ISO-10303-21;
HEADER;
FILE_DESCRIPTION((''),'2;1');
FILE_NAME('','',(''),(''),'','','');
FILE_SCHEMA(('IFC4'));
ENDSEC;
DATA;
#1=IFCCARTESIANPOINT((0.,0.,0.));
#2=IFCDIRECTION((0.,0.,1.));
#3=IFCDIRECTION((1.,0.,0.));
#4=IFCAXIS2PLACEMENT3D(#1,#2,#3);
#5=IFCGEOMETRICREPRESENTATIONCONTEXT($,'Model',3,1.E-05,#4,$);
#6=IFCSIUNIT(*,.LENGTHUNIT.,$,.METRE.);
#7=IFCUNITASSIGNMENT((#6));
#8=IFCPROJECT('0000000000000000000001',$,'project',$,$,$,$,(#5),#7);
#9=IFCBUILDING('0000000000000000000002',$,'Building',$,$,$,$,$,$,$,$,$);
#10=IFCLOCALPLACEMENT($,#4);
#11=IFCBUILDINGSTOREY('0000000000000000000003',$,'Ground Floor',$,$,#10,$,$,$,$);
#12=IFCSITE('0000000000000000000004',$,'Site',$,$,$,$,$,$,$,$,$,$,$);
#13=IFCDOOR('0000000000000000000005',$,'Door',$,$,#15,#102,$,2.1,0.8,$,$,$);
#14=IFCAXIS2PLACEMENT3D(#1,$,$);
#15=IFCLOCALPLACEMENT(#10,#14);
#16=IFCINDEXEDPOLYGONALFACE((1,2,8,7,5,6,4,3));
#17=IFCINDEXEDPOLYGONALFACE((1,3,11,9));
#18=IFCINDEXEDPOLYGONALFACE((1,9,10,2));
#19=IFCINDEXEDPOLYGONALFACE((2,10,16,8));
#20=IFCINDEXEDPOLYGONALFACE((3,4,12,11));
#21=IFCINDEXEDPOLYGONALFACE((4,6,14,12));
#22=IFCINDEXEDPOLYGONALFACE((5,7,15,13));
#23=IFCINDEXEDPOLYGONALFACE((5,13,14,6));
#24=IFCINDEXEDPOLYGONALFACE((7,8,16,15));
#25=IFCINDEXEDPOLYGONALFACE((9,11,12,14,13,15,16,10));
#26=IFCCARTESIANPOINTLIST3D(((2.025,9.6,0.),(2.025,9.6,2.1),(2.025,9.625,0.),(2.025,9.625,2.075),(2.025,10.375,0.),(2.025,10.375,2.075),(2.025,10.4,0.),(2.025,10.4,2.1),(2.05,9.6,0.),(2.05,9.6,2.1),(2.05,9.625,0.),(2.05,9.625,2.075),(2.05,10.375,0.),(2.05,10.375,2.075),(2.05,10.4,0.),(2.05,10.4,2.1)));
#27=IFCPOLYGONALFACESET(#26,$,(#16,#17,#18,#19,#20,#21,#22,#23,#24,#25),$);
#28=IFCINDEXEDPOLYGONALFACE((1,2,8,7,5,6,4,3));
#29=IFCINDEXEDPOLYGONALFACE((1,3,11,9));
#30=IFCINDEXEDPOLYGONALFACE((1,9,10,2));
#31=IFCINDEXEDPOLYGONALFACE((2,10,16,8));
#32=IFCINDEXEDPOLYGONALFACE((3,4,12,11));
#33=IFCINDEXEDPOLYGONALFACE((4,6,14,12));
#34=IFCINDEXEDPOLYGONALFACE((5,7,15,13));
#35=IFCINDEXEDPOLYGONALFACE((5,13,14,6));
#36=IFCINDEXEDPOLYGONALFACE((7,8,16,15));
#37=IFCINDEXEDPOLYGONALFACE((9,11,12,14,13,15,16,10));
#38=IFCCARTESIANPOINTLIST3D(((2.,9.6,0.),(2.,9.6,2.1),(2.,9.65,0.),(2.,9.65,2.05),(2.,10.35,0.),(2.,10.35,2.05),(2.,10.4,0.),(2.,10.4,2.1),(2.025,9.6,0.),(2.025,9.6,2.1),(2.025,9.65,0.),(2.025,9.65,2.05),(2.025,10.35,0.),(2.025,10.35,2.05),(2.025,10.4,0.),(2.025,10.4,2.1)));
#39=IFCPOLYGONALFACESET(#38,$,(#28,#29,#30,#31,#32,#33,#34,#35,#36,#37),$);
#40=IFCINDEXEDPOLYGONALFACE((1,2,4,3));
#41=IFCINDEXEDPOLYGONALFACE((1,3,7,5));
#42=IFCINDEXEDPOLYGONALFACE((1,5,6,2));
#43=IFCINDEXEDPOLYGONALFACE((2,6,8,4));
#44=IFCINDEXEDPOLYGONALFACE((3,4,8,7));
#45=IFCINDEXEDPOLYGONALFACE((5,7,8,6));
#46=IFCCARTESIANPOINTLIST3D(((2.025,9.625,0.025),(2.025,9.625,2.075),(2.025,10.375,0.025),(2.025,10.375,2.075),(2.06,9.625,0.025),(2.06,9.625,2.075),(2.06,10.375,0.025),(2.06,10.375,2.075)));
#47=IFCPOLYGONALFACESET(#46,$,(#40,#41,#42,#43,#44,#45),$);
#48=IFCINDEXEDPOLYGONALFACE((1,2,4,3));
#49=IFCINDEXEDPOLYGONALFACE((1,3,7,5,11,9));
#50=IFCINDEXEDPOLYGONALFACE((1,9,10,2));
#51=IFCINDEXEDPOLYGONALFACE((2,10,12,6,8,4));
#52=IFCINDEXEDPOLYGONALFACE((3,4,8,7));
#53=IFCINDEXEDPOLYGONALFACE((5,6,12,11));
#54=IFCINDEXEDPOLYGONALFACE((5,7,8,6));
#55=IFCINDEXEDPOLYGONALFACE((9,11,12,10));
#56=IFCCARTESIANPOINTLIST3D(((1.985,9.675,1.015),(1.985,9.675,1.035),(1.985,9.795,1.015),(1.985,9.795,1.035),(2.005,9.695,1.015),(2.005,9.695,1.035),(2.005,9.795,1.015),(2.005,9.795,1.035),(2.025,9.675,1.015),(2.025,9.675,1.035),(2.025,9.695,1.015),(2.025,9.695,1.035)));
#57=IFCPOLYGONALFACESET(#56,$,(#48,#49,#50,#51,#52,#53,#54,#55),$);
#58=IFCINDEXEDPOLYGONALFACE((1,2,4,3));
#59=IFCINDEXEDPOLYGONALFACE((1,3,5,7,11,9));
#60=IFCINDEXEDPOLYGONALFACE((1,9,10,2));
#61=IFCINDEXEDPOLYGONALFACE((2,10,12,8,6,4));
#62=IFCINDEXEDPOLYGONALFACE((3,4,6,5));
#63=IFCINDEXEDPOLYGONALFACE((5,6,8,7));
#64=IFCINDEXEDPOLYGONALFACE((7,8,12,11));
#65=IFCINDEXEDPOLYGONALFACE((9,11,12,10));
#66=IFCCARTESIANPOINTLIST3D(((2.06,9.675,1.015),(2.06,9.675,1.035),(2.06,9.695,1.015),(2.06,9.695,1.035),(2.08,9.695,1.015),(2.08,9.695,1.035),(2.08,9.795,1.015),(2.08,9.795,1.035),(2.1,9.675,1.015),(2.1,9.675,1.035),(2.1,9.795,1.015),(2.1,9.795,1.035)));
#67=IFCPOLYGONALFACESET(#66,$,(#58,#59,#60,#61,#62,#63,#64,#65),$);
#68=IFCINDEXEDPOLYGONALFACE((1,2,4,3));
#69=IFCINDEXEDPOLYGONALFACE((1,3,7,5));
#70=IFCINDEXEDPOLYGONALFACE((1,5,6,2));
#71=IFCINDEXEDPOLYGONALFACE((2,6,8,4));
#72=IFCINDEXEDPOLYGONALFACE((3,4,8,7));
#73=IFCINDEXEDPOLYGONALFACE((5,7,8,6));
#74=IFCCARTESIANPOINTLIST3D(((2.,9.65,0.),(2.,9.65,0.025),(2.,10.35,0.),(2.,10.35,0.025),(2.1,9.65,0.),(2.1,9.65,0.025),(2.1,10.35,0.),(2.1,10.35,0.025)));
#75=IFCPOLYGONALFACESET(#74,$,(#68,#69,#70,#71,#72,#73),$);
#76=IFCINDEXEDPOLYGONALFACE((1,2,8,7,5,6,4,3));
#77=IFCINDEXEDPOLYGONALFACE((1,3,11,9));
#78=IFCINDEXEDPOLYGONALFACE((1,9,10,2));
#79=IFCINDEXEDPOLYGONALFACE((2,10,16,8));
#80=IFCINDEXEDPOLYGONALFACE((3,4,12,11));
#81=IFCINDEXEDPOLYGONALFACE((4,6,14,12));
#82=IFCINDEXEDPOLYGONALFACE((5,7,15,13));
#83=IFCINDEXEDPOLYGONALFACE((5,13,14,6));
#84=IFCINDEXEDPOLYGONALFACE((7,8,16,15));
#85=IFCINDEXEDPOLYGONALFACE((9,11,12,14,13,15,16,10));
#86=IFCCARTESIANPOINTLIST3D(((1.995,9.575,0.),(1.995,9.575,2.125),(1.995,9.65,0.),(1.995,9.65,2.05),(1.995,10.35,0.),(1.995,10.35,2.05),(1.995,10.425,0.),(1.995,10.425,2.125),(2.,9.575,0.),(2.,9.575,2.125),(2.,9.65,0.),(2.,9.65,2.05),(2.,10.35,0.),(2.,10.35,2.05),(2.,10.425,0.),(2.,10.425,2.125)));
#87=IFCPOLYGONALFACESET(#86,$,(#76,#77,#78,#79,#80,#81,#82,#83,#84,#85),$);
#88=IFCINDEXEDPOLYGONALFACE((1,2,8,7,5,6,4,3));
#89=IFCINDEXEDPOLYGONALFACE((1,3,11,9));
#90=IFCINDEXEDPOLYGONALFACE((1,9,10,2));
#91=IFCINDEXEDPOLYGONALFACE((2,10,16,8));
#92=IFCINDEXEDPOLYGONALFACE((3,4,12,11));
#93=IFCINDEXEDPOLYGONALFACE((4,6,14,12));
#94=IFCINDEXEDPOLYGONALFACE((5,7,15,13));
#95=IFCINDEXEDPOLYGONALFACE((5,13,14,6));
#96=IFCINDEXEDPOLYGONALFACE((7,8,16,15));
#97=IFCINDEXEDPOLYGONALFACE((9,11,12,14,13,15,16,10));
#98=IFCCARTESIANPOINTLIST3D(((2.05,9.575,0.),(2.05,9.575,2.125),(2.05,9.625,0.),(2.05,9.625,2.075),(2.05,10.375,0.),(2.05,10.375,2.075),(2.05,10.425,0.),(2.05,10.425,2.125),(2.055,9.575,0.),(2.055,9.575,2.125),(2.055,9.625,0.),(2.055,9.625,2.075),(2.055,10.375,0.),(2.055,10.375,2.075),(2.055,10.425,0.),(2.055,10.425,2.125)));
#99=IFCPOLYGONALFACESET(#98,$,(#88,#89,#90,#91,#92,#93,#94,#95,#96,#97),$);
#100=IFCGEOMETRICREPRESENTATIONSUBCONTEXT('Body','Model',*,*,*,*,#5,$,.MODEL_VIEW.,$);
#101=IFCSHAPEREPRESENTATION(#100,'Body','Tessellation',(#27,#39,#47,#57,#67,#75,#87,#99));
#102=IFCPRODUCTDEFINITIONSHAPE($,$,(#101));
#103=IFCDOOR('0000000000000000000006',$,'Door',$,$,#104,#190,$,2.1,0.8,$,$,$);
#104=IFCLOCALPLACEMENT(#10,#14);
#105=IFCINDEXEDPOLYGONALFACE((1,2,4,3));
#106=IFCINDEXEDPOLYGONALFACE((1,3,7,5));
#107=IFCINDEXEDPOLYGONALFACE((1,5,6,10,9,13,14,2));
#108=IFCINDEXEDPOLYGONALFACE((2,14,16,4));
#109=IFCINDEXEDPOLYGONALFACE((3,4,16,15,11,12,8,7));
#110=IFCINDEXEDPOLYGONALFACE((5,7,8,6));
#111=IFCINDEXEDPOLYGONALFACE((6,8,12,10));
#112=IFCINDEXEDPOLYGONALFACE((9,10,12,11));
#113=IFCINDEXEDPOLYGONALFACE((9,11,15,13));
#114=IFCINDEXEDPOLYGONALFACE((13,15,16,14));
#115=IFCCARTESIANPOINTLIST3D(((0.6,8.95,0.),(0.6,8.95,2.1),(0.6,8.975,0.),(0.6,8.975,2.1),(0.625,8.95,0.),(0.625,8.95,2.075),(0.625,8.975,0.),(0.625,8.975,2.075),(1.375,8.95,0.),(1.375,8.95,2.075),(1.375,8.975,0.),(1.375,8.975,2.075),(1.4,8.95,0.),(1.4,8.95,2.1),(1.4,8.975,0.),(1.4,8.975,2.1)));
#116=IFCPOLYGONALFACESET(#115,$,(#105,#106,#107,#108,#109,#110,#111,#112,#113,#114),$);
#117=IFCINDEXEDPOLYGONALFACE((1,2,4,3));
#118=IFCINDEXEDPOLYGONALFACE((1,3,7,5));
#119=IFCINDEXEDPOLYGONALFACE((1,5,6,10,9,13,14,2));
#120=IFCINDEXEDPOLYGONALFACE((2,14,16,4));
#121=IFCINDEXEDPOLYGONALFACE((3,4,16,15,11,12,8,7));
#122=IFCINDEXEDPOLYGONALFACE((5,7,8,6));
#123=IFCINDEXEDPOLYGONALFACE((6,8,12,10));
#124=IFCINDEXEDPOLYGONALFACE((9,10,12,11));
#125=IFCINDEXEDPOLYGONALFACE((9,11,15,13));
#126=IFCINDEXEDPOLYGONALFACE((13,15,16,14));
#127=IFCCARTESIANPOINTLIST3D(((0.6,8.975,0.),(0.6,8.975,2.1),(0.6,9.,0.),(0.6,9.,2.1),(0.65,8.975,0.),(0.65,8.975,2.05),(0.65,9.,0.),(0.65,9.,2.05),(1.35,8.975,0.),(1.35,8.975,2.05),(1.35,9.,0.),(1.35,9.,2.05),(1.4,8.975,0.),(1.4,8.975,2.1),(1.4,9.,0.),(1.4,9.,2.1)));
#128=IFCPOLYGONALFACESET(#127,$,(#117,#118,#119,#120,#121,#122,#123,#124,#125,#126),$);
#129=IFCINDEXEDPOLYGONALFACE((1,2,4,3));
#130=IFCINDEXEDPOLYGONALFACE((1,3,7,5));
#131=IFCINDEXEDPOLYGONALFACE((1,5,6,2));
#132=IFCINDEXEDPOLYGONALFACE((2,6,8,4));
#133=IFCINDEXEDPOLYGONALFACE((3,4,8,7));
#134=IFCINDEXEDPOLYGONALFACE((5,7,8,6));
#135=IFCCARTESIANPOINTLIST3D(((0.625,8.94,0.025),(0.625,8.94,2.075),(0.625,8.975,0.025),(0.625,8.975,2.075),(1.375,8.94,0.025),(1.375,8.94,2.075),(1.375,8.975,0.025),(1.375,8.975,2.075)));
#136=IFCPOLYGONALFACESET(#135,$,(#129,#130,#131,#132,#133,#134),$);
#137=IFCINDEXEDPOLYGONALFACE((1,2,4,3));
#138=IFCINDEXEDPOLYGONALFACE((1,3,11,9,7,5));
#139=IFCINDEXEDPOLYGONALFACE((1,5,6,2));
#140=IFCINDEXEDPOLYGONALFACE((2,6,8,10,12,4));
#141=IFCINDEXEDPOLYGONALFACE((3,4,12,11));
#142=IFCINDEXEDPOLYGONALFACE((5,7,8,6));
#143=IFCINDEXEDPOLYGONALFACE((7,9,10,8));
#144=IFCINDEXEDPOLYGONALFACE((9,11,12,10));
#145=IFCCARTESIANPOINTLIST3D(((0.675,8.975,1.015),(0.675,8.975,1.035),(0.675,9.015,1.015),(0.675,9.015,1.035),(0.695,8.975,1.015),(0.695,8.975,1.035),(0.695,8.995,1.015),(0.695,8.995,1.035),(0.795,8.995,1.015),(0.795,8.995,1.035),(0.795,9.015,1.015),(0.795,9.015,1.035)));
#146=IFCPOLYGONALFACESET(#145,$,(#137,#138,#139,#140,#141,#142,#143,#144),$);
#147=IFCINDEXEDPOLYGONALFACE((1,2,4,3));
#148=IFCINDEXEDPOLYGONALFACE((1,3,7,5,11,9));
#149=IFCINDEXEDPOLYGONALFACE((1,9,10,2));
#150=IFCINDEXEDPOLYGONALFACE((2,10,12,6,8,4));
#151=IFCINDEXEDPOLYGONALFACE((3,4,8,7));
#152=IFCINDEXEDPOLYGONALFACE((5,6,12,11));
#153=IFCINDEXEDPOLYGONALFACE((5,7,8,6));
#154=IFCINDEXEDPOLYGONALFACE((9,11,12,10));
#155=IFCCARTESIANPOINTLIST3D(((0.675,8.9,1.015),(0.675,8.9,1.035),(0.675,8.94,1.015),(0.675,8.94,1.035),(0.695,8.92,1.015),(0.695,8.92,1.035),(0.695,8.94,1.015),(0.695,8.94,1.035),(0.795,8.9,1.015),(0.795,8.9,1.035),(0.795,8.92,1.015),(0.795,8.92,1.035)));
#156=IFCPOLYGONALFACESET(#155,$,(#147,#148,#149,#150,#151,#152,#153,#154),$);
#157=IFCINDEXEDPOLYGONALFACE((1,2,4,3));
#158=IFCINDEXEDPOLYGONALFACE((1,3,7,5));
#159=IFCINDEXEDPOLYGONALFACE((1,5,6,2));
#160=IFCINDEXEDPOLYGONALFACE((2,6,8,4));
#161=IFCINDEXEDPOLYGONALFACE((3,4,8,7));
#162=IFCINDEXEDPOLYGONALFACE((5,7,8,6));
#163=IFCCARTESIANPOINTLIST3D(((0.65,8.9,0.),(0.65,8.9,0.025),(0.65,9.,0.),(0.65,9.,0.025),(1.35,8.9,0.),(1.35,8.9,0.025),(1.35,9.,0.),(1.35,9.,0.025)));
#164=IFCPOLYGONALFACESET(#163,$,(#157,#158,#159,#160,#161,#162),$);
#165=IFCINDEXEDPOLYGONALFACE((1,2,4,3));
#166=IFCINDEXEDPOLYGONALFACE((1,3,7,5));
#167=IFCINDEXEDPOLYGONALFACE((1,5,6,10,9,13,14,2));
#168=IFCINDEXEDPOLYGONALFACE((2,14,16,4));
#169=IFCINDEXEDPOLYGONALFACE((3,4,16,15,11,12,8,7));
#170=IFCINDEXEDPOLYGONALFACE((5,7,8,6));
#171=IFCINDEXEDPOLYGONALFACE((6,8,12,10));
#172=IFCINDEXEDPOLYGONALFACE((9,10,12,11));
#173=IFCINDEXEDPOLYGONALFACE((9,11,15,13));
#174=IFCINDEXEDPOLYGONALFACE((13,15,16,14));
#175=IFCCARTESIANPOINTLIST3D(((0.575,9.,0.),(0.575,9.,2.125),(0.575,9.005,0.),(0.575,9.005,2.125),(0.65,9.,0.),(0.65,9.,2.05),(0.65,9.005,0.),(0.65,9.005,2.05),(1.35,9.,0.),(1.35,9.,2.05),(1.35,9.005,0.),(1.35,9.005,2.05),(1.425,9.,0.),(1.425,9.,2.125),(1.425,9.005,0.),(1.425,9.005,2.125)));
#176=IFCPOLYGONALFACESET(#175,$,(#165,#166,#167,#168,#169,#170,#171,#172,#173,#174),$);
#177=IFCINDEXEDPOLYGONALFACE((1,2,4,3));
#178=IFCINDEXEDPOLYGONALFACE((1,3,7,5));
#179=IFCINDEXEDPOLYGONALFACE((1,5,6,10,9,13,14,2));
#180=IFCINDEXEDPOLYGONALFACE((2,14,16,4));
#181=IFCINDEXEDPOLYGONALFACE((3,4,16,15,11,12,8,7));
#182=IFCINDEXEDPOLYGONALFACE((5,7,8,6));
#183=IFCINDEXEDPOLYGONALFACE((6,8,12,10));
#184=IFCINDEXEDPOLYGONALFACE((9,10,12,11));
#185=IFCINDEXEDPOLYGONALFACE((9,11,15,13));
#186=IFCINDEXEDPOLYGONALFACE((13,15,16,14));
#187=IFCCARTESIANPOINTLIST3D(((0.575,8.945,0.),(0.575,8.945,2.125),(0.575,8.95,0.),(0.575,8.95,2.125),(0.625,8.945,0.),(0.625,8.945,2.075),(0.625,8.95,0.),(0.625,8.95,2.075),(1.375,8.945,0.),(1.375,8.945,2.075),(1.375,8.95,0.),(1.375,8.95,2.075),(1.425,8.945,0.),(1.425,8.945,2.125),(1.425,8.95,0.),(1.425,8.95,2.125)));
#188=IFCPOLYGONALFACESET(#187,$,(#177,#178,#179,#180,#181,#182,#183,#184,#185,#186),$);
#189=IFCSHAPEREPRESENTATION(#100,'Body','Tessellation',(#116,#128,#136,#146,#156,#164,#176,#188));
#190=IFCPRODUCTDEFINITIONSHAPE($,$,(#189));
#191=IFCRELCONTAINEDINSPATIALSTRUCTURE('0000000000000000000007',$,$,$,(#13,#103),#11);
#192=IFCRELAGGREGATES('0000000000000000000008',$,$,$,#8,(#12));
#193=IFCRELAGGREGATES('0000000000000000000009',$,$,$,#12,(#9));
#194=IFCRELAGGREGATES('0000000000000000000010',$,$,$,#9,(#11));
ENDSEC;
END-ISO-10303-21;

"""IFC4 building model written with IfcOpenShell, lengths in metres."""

from ifc_helpers import new_model, si_unit, frame, origin_with_axes, place, context, subcontext, project, spatial, line, indexed_curve, outline, extrude, element, save


model = new_model("IFC4")

# Units and contexts
model_context = context("Model", 3, precision=1e-05, world=origin_with_axes())
body_context = subcontext(model_context, "Body", "Model", "MODEL_VIEW")
ifc_project = project(units=[si_unit("LENGTHUNIT", "METRE")], contexts=[model_context])

# Site, building, storey
site = spatial("IfcSite", under=ifc_project, Name="Site")
building = spatial("IfcBuilding", under=site, Name="Building")
storey_placement = place(None, origin_with_axes())
storey = spatial("IfcBuildingStorey", under=building, at=storey_placement, Name="Ground Floor")

# Doors
door_1_placement = place(storey_placement, frame((2.0, 10.4, 0.0), z_axis=(0.0, 0.0, 1.0), x_axis=(0.0, -1.0, 0.0)))
element("IfcDoor", 1, at=door_1_placement, inside=storey, Name="Door", OverallHeight=2.1, OverallWidth=0.8, context=body_context, shape_type="SweptSolid", body=[
    extrude(outline(indexed_curve([(0.0, 0.0), (0.0, 2.1), (0.8, 2.1), (0.8, 0.0), (0.775, 0.0), (0.775, 2.075), (0.025, 2.075), (0.025, 0.0)], segments=[line(1, 2, 3, 4, 5, 6, 7, 8, 1)])), frame((0.0, 0.025, 0.0), z_axis=(0.0, -1.0, 0.0), x_axis=(1.0, 0.0, 0.0)), (0.0, 0.0, -1.0), 0.025),
    extrude(outline(indexed_curve([(0.0, 0.0), (0.0, 2.1), (0.8, 2.1), (0.8, 0.0), (0.75, 0.0), (0.75, 2.05), (0.05, 2.05), (0.05, 0.0)], segments=[line(1, 2, 3, 4, 5, 6, 7, 8, 1)])), frame((0.0, 0.0, 0.0), z_axis=(0.0, -1.0, 0.0), x_axis=(1.0, 0.0, 0.0)), (0.0, 0.0, -1.0), 0.025),
    extrude(outline(indexed_curve([(0.0, 0.0), (0.75, 0.0), (0.75, 0.035), (0.0, 0.035)], segments=[line(1, 2, 3, 4, 1)])), frame((0.025, 0.025, 0.025), z_axis=(0.0, 0.0, 1.0), x_axis=(1.0, 0.0, 0.0)), (0.0, 0.0, 1.0), 2.05),
    extrude(outline(indexed_curve([(0.0, 0.0), (0.0, -0.04), (-0.12, -0.04), (-0.12, -0.02), (-0.02, -0.02), (-0.02, 0.0)], segments=[line(1, 2, 3, 4, 5, 6, 1)])), frame((0.725, 0.025, 1.015), z_axis=(0.0, 0.0, 1.0), x_axis=(1.0, 0.0, 0.0)), (0.0, 0.0, 1.0), 0.02),
    extrude(outline(indexed_curve([(0.0, 0.0), (0.0, 0.04), (-0.12, 0.04), (-0.12, 0.02), (-0.02, 0.02), (-0.02, 0.0)], segments=[line(1, 2, 3, 4, 5, 6, 1)])), frame((0.725, 0.06, 1.015), z_axis=(0.0, 0.0, 1.0), x_axis=(1.0, 0.0, 0.0)), (0.0, 0.0, 1.0), 0.02),
    extrude(outline(indexed_curve([(0.0, 0.0), (0.7, 0.0), (0.7, 0.1), (0.0, 0.1)], segments=[line(1, 2, 3, 4, 1)])), frame((0.05, 0.0, 0.0), z_axis=(0.0, 0.0, 1.0), x_axis=(1.0, 0.0, 0.0)), (0.0, 0.0, 1.0), 0.025),
    extrude(outline(indexed_curve([(0.0, 0.0), (0.0, 2.125), (0.85, 2.125), (0.85, 0.0), (0.775, 0.0), (0.775, 2.05), (0.075, 2.05), (0.075, 0.0)], segments=[line(1, 2, 3, 4, 5, 6, 7, 8, 1)])), frame((-0.025, -0.005, 0.0), z_axis=(0.0, -1.0, 0.0), x_axis=(1.0, 0.0, 0.0)), (0.0, 0.0, -1.0), 0.005),
    extrude(outline(indexed_curve([(0.0, 0.0), (0.0, 2.125), (0.85, 2.125), (0.85, 0.0), (0.8, 0.0), (0.8, 2.075), (0.05, 2.075), (0.05, 0.0)], segments=[line(1, 2, 3, 4, 5, 6, 7, 8, 1)])), frame((-0.025, 0.05, 0.0), z_axis=(0.0, -1.0, 0.0), x_axis=(1.0, 0.0, 0.0)), (0.0, 0.0, -1.0), 0.005),
])
door_2_placement = place(storey_placement, frame((1.4, 9.0, 0.0), z_axis=(0.0, 0.0, 1.0), x_axis=(-1.0, 0.0, 0.0)))
element("IfcDoor", 2, at=door_2_placement, inside=storey, Name="Door", OverallHeight=2.1, OverallWidth=0.8, context=body_context, shape_type="SweptSolid", body=[
    extrude(outline(indexed_curve([(0.0, 0.0), (0.0, 2.1), (0.8, 2.1), (0.8, 0.0), (0.775, 0.0), (0.775, 2.075), (0.025, 2.075), (0.025, 0.0)], segments=[line(1, 2, 3, 4, 5, 6, 7, 8, 1)])), frame((0.0, 0.025, 0.0), z_axis=(0.0, -1.0, 0.0), x_axis=(1.0, 0.0, 0.0)), (0.0, 0.0, -1.0), 0.025),
    extrude(outline(indexed_curve([(0.0, 0.0), (0.0, 2.1), (0.8, 2.1), (0.8, 0.0), (0.75, 0.0), (0.75, 2.05), (0.05, 2.05), (0.05, 0.0)], segments=[line(1, 2, 3, 4, 5, 6, 7, 8, 1)])), frame((0.0, 0.0, 0.0), z_axis=(0.0, -1.0, 0.0), x_axis=(1.0, 0.0, 0.0)), (0.0, 0.0, -1.0), 0.025),
    extrude(outline(indexed_curve([(0.0, 0.0), (0.75, 0.0), (0.75, 0.035), (0.0, 0.035)], segments=[line(1, 2, 3, 4, 1)])), frame((0.025, 0.025, 0.025), z_axis=(0.0, 0.0, 1.0), x_axis=(1.0, 0.0, 0.0)), (0.0, 0.0, 1.0), 2.05),
    extrude(outline(indexed_curve([(0.0, 0.0), (0.0, -0.04), (-0.12, -0.04), (-0.12, -0.02), (-0.02, -0.02), (-0.02, 0.0)], segments=[line(1, 2, 3, 4, 5, 6, 1)])), frame((0.725, 0.025, 1.015), z_axis=(0.0, 0.0, 1.0), x_axis=(1.0, 0.0, 0.0)), (0.0, 0.0, 1.0), 0.02),
    extrude(outline(indexed_curve([(0.0, 0.0), (0.0, 0.04), (-0.12, 0.04), (-0.12, 0.02), (-0.02, 0.02), (-0.02, 0.0)], segments=[line(1, 2, 3, 4, 5, 6, 1)])), frame((0.725, 0.06, 1.015), z_axis=(0.0, 0.0, 1.0), x_axis=(1.0, 0.0, 0.0)), (0.0, 0.0, 1.0), 0.02),
    extrude(outline(indexed_curve([(0.0, 0.0), (0.7, 0.0), (0.7, 0.1), (0.0, 0.1)], segments=[line(1, 2, 3, 4, 1)])), frame((0.05, 0.0, 0.0), z_axis=(0.0, 0.0, 1.0), x_axis=(1.0, 0.0, 0.0)), (0.0, 0.0, 1.0), 0.025),
    extrude(outline(indexed_curve([(0.0, 0.0), (0.0, 2.125), (0.85, 2.125), (0.85, 0.0), (0.775, 0.0), (0.775, 2.05), (0.075, 2.05), (0.075, 0.0)], segments=[line(1, 2, 3, 4, 5, 6, 7, 8, 1)])), frame((-0.025, -0.005, 0.0), z_axis=(0.0, -1.0, 0.0), x_axis=(1.0, 0.0, 0.0)), (0.0, 0.0, -1.0), 0.005),
    extrude(outline(indexed_curve([(0.0, 0.0), (0.0, 2.125), (0.85, 2.125), (0.85, 0.0), (0.8, 0.0), (0.8, 2.075), (0.05, 2.075), (0.05, 0.0)], segments=[line(1, 2, 3, 4, 5, 6, 7, 8, 1)])), frame((-0.025, 0.05, 0.0), z_axis=(0.0, -1.0, 0.0), x_axis=(1.0, 0.0, 0.0)), (0.0, 0.0, -1.0), 0.005),
])

save(model, "model.ifc")
